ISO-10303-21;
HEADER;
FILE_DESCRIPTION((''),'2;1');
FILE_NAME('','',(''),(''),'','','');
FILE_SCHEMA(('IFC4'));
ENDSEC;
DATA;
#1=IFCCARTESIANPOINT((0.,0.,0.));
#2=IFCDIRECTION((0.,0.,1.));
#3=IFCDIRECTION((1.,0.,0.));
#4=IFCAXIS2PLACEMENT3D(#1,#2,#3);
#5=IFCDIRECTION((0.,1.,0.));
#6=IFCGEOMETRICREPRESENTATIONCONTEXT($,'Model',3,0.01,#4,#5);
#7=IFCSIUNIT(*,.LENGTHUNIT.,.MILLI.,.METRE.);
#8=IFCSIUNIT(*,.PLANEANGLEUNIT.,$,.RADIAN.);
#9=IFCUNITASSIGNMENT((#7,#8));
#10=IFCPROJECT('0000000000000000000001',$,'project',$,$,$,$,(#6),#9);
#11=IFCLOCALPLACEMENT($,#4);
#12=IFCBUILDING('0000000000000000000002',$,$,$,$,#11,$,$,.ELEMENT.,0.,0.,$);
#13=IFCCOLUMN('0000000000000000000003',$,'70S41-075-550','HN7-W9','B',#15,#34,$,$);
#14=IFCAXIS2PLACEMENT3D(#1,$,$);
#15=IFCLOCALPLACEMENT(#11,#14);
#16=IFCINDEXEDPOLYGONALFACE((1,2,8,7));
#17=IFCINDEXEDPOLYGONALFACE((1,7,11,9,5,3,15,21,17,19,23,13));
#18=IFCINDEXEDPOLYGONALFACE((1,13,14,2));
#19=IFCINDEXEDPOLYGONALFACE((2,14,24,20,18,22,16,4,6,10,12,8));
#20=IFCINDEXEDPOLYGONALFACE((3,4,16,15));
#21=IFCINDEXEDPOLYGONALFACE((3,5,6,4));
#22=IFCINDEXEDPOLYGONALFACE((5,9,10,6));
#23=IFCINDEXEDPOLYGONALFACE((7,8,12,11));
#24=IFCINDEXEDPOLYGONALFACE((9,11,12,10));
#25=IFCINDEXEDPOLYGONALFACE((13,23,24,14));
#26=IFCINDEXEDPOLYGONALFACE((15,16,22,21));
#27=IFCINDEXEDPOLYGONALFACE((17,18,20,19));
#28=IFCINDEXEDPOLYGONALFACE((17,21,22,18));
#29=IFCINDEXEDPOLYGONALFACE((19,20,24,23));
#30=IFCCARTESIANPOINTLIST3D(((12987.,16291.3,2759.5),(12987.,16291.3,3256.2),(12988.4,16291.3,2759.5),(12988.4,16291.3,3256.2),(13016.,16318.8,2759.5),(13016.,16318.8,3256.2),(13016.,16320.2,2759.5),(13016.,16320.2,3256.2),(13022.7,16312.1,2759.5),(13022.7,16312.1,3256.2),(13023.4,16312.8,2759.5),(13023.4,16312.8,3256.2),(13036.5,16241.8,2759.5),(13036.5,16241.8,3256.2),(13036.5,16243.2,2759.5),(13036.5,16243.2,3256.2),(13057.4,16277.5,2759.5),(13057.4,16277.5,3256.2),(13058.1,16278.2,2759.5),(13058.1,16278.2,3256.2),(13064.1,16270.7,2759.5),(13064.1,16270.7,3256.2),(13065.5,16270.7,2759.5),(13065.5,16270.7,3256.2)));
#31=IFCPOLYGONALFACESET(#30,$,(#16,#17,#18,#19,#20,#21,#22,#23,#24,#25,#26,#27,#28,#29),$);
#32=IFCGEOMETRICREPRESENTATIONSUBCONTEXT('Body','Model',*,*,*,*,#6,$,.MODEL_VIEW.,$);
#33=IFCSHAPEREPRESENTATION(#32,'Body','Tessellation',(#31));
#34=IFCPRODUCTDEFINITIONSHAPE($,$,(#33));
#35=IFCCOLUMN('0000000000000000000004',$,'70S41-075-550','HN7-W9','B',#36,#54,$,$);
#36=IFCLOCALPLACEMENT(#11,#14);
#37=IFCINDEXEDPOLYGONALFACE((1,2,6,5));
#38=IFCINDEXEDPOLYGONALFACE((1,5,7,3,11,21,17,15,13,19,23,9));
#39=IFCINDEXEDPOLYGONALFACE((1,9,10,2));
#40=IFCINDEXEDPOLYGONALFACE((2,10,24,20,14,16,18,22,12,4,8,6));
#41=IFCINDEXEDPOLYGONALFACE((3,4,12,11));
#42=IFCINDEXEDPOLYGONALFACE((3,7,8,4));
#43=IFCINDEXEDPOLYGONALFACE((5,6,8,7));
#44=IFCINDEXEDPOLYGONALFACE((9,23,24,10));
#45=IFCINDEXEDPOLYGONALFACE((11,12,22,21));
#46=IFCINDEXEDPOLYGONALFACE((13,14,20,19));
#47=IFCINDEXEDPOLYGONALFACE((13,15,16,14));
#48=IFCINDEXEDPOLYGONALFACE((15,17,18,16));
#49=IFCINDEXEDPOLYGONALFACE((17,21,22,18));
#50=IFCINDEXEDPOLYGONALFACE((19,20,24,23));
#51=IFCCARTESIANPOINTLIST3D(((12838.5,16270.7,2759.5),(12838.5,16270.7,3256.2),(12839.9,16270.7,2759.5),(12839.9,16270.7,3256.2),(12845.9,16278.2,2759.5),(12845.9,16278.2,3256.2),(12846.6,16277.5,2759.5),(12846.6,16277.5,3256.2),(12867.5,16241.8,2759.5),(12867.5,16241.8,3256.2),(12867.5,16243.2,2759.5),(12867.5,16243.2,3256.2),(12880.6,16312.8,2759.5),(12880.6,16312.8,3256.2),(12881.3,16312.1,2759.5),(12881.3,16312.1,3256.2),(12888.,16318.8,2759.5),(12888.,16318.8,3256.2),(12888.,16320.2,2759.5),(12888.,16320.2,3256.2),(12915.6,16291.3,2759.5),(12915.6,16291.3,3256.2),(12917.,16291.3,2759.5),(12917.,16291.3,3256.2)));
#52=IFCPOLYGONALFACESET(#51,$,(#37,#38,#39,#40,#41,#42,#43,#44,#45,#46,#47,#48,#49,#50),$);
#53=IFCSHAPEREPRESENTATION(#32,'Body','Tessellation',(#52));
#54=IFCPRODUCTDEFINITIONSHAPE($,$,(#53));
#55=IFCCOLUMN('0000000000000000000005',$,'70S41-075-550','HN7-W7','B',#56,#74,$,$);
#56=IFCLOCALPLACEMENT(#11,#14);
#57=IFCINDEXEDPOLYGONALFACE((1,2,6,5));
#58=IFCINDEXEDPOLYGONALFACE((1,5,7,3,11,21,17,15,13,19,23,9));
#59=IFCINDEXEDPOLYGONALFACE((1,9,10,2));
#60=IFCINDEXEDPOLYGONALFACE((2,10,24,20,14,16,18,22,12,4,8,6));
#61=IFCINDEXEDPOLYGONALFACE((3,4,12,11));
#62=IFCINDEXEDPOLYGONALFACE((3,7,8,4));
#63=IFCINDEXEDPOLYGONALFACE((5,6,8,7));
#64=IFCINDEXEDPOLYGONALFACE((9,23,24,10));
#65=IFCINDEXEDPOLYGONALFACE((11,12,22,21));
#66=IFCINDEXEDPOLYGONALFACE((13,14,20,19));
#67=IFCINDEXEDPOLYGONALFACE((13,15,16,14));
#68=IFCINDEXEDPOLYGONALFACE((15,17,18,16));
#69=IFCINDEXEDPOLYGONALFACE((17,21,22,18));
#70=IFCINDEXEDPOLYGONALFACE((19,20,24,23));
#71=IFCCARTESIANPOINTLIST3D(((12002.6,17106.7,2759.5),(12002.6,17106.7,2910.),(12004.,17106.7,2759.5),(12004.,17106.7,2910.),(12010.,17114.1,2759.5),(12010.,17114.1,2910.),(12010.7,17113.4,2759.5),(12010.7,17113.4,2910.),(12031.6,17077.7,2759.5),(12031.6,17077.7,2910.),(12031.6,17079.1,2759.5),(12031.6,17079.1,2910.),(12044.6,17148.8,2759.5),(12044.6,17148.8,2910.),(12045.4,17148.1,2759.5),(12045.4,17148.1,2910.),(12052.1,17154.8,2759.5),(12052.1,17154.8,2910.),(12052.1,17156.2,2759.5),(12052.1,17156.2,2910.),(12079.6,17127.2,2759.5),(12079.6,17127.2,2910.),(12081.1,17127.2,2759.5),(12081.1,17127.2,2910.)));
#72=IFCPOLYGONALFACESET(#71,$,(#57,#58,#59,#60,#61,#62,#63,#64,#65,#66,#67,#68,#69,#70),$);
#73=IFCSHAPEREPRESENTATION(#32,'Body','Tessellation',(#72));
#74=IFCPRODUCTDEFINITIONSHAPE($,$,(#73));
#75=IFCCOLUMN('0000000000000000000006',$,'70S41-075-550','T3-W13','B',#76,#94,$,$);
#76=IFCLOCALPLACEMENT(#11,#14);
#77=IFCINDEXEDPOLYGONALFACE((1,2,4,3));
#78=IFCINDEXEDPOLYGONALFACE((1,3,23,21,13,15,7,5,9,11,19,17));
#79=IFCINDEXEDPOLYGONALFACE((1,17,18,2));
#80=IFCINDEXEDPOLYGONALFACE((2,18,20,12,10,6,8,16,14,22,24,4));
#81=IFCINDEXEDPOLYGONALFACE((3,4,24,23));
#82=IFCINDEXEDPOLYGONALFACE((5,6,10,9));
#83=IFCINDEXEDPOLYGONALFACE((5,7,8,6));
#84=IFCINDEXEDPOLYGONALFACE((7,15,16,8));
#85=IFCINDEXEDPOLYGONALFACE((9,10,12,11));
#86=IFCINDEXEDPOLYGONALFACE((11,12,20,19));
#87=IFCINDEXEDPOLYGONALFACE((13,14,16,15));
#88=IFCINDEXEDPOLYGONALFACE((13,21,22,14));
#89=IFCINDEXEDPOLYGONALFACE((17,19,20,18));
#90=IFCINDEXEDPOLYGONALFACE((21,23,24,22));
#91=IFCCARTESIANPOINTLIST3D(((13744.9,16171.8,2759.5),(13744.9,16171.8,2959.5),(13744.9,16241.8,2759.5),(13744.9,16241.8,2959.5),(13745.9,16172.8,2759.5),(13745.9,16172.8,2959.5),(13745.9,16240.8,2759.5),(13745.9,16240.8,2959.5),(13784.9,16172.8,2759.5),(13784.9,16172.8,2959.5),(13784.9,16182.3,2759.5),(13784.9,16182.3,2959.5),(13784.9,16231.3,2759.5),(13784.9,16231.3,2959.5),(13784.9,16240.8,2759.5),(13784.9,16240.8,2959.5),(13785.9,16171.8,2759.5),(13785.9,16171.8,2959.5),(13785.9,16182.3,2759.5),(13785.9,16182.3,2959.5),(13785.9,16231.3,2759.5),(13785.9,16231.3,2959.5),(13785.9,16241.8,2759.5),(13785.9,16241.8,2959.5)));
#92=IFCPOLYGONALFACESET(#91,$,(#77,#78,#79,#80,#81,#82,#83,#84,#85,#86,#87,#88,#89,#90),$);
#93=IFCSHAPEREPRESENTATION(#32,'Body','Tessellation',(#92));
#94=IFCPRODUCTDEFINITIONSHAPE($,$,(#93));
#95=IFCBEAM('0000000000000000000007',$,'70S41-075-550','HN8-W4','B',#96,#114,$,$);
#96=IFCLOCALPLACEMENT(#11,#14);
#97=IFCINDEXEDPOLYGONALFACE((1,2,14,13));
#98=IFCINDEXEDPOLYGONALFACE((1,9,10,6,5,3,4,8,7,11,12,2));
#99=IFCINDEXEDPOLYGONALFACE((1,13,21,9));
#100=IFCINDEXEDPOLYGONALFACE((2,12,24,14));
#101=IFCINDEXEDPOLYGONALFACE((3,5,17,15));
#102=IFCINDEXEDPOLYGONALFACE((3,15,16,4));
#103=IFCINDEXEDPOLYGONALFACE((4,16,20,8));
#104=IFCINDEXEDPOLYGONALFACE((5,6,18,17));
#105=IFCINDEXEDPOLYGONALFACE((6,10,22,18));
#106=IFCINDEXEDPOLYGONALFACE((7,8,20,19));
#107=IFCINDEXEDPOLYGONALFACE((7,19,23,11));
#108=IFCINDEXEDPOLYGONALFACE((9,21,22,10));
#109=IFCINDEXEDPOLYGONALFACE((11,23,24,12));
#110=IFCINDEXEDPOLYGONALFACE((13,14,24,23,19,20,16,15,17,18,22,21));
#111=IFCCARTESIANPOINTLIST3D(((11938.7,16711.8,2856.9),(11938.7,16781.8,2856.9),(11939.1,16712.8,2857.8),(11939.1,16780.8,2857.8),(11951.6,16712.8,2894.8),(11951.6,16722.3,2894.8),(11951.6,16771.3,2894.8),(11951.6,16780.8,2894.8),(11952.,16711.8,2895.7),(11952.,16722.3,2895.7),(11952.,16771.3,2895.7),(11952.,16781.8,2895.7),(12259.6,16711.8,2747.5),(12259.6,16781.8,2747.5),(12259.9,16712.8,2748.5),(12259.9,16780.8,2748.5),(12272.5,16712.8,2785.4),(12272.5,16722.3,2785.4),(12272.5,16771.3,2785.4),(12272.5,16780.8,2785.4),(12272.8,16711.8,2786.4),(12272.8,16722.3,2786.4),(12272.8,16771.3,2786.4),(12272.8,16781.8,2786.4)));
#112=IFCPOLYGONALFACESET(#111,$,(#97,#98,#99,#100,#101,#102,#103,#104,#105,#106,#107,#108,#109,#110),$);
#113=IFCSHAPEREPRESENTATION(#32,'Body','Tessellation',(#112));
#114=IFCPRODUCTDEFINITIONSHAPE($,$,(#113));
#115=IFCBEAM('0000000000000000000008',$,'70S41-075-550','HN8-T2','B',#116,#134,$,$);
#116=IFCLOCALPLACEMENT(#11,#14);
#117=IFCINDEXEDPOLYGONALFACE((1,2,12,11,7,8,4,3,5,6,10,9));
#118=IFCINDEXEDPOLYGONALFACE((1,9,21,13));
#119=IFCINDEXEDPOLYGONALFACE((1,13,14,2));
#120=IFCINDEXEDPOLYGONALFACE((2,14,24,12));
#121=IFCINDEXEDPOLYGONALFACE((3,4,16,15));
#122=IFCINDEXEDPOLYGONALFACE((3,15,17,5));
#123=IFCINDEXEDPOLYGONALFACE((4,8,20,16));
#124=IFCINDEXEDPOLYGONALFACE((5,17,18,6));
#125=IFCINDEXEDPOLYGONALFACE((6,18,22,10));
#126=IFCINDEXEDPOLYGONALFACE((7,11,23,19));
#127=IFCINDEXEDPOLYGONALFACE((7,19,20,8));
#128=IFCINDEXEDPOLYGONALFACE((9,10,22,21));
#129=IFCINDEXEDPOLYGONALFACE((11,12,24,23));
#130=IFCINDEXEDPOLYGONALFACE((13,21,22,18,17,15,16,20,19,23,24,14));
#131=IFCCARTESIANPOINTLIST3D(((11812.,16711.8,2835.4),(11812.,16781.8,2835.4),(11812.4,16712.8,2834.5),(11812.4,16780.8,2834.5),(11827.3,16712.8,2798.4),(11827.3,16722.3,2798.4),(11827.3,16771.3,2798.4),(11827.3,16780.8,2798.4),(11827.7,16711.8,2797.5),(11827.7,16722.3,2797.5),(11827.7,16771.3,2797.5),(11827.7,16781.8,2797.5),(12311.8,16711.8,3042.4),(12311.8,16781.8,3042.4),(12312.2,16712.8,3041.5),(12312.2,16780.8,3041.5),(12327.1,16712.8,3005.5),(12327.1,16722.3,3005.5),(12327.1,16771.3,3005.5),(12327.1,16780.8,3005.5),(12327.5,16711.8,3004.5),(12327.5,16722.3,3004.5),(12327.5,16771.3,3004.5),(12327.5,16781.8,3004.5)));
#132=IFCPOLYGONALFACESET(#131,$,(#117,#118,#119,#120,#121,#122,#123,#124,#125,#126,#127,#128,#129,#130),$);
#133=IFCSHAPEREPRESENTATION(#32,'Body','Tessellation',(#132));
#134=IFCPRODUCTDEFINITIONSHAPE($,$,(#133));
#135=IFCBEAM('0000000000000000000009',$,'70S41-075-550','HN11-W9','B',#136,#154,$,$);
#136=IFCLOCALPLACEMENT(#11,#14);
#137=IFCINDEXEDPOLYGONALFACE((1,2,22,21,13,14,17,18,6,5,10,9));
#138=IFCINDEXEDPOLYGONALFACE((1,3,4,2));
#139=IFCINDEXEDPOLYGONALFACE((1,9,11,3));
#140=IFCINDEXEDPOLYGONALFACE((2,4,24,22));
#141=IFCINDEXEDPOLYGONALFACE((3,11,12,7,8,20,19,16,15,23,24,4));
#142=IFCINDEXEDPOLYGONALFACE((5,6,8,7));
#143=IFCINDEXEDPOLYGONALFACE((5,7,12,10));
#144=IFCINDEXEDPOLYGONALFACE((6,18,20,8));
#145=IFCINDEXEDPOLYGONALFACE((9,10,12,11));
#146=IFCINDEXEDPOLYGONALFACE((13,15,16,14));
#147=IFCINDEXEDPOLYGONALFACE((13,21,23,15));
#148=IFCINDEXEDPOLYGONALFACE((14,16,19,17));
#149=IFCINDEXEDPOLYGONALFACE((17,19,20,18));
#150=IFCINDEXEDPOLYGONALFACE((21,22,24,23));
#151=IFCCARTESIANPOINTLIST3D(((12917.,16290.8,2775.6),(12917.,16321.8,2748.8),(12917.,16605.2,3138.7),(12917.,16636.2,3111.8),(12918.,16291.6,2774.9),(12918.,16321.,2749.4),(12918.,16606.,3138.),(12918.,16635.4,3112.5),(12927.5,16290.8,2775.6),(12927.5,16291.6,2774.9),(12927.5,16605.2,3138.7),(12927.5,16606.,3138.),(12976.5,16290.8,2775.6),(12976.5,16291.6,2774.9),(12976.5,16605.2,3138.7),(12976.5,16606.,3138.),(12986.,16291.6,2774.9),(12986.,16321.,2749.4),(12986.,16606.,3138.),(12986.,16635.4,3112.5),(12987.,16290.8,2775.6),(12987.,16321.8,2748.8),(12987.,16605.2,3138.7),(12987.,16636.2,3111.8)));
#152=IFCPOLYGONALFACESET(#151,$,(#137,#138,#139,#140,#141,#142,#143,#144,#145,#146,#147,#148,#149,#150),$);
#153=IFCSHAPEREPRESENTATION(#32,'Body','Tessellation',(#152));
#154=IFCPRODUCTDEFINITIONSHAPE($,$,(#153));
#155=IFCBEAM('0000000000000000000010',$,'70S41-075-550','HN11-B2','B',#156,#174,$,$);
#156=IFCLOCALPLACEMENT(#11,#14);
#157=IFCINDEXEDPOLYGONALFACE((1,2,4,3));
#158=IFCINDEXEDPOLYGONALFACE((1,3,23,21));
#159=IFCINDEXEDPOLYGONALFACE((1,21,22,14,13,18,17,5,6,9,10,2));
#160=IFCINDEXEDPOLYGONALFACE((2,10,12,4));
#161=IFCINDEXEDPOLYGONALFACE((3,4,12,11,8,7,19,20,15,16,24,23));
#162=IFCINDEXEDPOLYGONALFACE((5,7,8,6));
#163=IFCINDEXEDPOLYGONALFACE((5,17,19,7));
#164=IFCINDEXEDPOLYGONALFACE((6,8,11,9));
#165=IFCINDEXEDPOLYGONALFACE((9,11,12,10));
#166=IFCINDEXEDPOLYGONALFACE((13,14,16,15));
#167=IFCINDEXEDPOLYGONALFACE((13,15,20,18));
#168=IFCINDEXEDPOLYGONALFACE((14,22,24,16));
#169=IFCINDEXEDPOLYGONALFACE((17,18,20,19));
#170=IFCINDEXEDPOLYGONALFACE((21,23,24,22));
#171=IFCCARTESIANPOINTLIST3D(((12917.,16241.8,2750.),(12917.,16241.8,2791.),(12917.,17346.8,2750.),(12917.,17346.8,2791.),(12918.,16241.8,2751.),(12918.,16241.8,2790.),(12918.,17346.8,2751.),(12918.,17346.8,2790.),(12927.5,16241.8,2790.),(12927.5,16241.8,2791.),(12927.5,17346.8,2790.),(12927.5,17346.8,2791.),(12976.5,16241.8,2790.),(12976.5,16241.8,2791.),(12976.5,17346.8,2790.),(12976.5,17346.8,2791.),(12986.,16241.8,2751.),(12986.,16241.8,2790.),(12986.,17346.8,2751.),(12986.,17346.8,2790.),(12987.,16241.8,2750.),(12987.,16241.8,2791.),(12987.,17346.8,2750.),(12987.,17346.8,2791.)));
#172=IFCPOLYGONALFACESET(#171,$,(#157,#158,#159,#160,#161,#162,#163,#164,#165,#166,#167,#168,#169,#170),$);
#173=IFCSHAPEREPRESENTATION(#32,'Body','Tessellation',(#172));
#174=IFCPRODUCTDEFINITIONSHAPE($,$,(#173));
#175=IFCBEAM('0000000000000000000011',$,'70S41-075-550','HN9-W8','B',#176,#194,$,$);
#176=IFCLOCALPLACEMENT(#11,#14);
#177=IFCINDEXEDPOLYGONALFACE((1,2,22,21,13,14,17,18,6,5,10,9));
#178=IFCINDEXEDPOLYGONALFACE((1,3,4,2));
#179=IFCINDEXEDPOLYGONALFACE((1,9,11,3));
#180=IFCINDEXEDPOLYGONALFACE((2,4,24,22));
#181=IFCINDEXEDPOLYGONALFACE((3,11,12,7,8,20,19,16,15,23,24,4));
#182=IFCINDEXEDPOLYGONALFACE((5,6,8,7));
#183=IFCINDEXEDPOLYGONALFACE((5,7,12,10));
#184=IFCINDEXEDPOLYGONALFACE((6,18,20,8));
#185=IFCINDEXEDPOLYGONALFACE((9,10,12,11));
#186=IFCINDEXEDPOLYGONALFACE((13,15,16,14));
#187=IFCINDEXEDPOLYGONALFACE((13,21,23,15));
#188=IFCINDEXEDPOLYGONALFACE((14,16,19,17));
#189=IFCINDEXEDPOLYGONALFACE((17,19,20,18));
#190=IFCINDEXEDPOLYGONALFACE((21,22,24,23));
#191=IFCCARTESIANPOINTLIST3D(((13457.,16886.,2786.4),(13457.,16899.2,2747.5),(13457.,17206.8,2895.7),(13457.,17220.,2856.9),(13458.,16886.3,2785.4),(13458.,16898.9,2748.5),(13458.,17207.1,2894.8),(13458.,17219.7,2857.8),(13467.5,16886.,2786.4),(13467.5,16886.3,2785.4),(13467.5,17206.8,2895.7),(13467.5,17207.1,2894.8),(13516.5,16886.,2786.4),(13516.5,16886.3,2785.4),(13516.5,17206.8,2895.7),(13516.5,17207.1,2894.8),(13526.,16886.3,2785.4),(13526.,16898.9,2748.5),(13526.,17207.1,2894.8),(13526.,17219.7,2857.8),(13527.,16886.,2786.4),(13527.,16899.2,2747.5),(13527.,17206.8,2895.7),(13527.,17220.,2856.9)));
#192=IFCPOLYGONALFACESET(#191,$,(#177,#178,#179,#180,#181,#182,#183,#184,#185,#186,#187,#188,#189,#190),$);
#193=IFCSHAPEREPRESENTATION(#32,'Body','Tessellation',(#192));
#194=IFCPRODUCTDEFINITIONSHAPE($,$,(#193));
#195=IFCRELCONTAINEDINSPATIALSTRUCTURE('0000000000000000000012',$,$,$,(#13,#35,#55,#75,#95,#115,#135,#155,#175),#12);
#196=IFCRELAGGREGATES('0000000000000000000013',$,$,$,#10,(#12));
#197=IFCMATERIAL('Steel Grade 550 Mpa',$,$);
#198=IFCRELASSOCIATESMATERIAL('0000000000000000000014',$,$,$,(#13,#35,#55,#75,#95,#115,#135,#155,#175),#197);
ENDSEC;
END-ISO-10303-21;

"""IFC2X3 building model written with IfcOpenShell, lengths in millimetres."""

from ifc_helpers import new_model, si_unit, direction, frame, origin, origin_with_axes, origin_2d_with_axis, place, context, subcontext, project, spatial, c_section, extrude, source, transform, mapped, material, element, save


model = new_model("IFC2X3")

# Units and contexts
model_context = context("Model", 3, precision=0.01, world=origin_with_axes(), true_north=direction((0.0, 1.0, 0.0)))
body_context = subcontext(model_context, "Body", "Model", "MODEL_VIEW")
ifc_project = project(units=[si_unit("LENGTHUNIT", "METRE", prefix="MILLI"), si_unit("PLANEANGLEUNIT", "RADIAN")], contexts=[model_context])

# Building
building_placement = place(None, origin_with_axes())
building = spatial("IfcBuilding", under=ifc_project, at=building_placement, CompositionType="ELEMENT", ElevationOfRefHeight=0.0, ElevationOfTerrain=0.0)

# Columns
ifc_material = material(Name="Steel Grade 550 Mpa")
shared_shape_1 = source(origin(), body_context, "Body", "SweptSolid", [
    extrude(c_section(Depth=70.0, Width=41.0, WallThickness=1.0, Girth=10.5, at=origin_2d_with_axis()), origin_with_axes(), (0.0, 0.0, 1.0), 496.7),
])
column_1_placement = place(None, frame((13026.3, 16281.0, 2759.5), z_axis=(0.0, 0.0, 1.0), x_axis=(0.707107, 0.707107, 0.0)))
element("IfcColumn", 1, at=column_1_placement, inside=building, material=ifc_material, Name="70S41-075-550", Description="HN7-W9", ObjectType="B", context=body_context, shape_type="MappedRepresentation", body=[
    mapped(shared_shape_1, transform((0.0, 0.0, 0.0), scale=1.0)),
])
shared_shape_2 = source(origin(), body_context, "Body", "SweptSolid", [
    extrude(c_section(Depth=70.0, Width=41.0, WallThickness=1.0, Girth=10.5, at=origin_2d_with_axis()), origin_with_axes(), (0.0, 0.0, 1.0), 496.7),
])
column_2_placement = place(None, frame((12877.8, 16281.0, 2759.5), z_axis=(0.0, 0.0, 1.0), x_axis=(-0.707107, 0.707107, 0.0)))
element("IfcColumn", 2, at=column_2_placement, inside=building, material=ifc_material, Name="70S41-075-550", Description="HN7-W9", ObjectType="B", context=body_context, shape_type="MappedRepresentation", body=[
    mapped(shared_shape_2, transform((0.0, 0.0, 0.0), scale=1.0)),
])
shared_shape_3 = source(origin(), body_context, "Body", "SweptSolid", [
    extrude(c_section(Depth=70.0, Width=41.0, WallThickness=1.0, Girth=10.5, at=origin_2d_with_axis()), origin_with_axes(), (0.0, 0.0, 1.0), 150.5),
])
column_3_placement = place(None, frame((12041.8, 17116.9, 2759.5), z_axis=(0.0, 0.0, 1.0), x_axis=(-0.707107, 0.707107, 0.0)))
element("IfcColumn", 3, at=column_3_placement, inside=building, material=ifc_material, Name="70S41-075-550", Description="HN7-W7", ObjectType="B", context=body_context, shape_type="MappedRepresentation", body=[
    mapped(shared_shape_3, transform((0.0, 0.0, 0.0), scale=1.0)),
])
shared_shape_4 = source(origin(), body_context, "Body", "SweptSolid", [
    extrude(c_section(Depth=70.0, Width=41.0, WallThickness=1.0, Girth=10.5, at=origin_2d_with_axis()), origin_with_axes(), (0.0, 0.0, 1.0), 200.0),
])
column_4_placement = place(None, frame((13765.4, 16206.8, 2959.5), z_axis=(0.0, 0.0, -1.0), x_axis=(1.0, 0.0, 0.0)))
element("IfcColumn", 4, at=column_4_placement, inside=building, material=ifc_material, Name="70S41-075-550", Description="T3-W13", ObjectType="B", context=body_context, shape_type="MappedRepresentation", body=[
    mapped(shared_shape_4, transform((0.0, 0.0, 0.0), scale=1.0)),
])

# Beams
shared_shape_5 = source(origin(), body_context, "Body", "SweptSolid", [
    extrude(c_section(Depth=70.0, Width=41.0, WallThickness=1.0, Girth=10.5, at=origin_2d_with_axis()), origin_with_axes(), (0.0, 0.0, 1.0), 338.9),
])
beam_1_placement = place(None, frame((11945.3, 16746.8, 2876.3), z_axis=(0.946528, 0.0, -0.322621), x_axis=(0.322621, 0.0, 0.946528)))
element("IfcBeam", 5, at=beam_1_placement, inside=building, material=ifc_material, Name="70S41-075-550", Description="HN8-W4", ObjectType="B", context=body_context, shape_type="MappedRepresentation", body=[
    mapped(shared_shape_5, transform((0.0, 0.0, 0.0), scale=1.0)),
])
shared_shape_6 = source(origin(), body_context, "Body", "SweptSolid", [
    extrude(c_section(Depth=70.0, Width=41.0, WallThickness=1.0, Girth=10.5, at=origin_2d_with_axis()), origin_with_axes(), (0.0, 0.0, 1.0), 541.0),
])
beam_2_placement = place(None, frame((12319.7, 16746.8, 3023.5), z_axis=(-0.92388, 0.0, -0.382683), x_axis=(0.382683, 0.0, -0.92388)))
element("IfcBeam", 6, at=beam_2_placement, inside=building, material=ifc_material, Name="70S41-075-550", Description="HN8-T2", ObjectType="B", context=body_context, shape_type="MappedRepresentation", body=[
    mapped(shared_shape_6, transform((0.0, 0.0, 0.0), scale=1.0)),
])
shared_shape_7 = source(origin(), body_context, "Body", "SweptSolid", [
    extrude(c_section(Depth=70.0, Width=41.0, WallThickness=1.0, Girth=10.5, at=origin_2d_with_axis()), origin_with_axes(), (0.0, 0.0, 1.0), 480.3),
])
beam_3_placement = place(None, frame((12952.0, 16620.7, 3125.2), z_axis=(0.0, -0.654629, -0.75595), x_axis=(0.0, -0.75595, 0.654629)))
element("IfcBeam", 7, at=beam_3_placement, inside=building, material=ifc_material, Name="70S41-075-550", Description="HN11-W9", ObjectType="B", context=body_context, shape_type="MappedRepresentation", body=[
    mapped(shared_shape_7, transform((0.0, 0.0, 0.0), scale=1.0)),
])
shared_shape_8 = source(origin(), body_context, "Body", "SweptSolid", [
    extrude(c_section(Depth=70.0, Width=41.0, WallThickness=1.0, Girth=10.5, at=origin_2d_with_axis()), origin_with_axes(), (0.0, 0.0, 1.0), 1105.0),
])
beam_4_placement = place(None, frame((12952.0, 17346.8, 2770.5), z_axis=(0.0, -1.0, 0.0), x_axis=(0.0, 0.0, 1.0)))
element("IfcBeam", 8, at=beam_4_placement, inside=building, material=ifc_material, Name="70S41-075-550", Description="HN11-B2", ObjectType="B", context=body_context, shape_type="MappedRepresentation", body=[
    mapped(shared_shape_8, transform((0.0, 0.0, 0.0), scale=1.0)),
])
shared_shape_9 = source(origin(), body_context, "Body", "SweptSolid", [
    extrude(c_section(Depth=70.0, Width=41.0, WallThickness=1.0, Girth=10.5, at=origin_2d_with_axis()), origin_with_axes(), (0.0, 0.0, 1.0), 338.9),
])
beam_5_placement = place(None, frame((13492.0, 17213.4, 2876.3), z_axis=(0.0, -0.946528, -0.322621), x_axis=(0.0, -0.322621, 0.946528)))
element("IfcBeam", 9, at=beam_5_placement, inside=building, material=ifc_material, Name="70S41-075-550", Description="HN9-W8", ObjectType="B", context=body_context, shape_type="MappedRepresentation", body=[
    mapped(shared_shape_9, transform((0.0, 0.0, 0.0), scale=1.0)),
])

save(model, "model.ifc")
